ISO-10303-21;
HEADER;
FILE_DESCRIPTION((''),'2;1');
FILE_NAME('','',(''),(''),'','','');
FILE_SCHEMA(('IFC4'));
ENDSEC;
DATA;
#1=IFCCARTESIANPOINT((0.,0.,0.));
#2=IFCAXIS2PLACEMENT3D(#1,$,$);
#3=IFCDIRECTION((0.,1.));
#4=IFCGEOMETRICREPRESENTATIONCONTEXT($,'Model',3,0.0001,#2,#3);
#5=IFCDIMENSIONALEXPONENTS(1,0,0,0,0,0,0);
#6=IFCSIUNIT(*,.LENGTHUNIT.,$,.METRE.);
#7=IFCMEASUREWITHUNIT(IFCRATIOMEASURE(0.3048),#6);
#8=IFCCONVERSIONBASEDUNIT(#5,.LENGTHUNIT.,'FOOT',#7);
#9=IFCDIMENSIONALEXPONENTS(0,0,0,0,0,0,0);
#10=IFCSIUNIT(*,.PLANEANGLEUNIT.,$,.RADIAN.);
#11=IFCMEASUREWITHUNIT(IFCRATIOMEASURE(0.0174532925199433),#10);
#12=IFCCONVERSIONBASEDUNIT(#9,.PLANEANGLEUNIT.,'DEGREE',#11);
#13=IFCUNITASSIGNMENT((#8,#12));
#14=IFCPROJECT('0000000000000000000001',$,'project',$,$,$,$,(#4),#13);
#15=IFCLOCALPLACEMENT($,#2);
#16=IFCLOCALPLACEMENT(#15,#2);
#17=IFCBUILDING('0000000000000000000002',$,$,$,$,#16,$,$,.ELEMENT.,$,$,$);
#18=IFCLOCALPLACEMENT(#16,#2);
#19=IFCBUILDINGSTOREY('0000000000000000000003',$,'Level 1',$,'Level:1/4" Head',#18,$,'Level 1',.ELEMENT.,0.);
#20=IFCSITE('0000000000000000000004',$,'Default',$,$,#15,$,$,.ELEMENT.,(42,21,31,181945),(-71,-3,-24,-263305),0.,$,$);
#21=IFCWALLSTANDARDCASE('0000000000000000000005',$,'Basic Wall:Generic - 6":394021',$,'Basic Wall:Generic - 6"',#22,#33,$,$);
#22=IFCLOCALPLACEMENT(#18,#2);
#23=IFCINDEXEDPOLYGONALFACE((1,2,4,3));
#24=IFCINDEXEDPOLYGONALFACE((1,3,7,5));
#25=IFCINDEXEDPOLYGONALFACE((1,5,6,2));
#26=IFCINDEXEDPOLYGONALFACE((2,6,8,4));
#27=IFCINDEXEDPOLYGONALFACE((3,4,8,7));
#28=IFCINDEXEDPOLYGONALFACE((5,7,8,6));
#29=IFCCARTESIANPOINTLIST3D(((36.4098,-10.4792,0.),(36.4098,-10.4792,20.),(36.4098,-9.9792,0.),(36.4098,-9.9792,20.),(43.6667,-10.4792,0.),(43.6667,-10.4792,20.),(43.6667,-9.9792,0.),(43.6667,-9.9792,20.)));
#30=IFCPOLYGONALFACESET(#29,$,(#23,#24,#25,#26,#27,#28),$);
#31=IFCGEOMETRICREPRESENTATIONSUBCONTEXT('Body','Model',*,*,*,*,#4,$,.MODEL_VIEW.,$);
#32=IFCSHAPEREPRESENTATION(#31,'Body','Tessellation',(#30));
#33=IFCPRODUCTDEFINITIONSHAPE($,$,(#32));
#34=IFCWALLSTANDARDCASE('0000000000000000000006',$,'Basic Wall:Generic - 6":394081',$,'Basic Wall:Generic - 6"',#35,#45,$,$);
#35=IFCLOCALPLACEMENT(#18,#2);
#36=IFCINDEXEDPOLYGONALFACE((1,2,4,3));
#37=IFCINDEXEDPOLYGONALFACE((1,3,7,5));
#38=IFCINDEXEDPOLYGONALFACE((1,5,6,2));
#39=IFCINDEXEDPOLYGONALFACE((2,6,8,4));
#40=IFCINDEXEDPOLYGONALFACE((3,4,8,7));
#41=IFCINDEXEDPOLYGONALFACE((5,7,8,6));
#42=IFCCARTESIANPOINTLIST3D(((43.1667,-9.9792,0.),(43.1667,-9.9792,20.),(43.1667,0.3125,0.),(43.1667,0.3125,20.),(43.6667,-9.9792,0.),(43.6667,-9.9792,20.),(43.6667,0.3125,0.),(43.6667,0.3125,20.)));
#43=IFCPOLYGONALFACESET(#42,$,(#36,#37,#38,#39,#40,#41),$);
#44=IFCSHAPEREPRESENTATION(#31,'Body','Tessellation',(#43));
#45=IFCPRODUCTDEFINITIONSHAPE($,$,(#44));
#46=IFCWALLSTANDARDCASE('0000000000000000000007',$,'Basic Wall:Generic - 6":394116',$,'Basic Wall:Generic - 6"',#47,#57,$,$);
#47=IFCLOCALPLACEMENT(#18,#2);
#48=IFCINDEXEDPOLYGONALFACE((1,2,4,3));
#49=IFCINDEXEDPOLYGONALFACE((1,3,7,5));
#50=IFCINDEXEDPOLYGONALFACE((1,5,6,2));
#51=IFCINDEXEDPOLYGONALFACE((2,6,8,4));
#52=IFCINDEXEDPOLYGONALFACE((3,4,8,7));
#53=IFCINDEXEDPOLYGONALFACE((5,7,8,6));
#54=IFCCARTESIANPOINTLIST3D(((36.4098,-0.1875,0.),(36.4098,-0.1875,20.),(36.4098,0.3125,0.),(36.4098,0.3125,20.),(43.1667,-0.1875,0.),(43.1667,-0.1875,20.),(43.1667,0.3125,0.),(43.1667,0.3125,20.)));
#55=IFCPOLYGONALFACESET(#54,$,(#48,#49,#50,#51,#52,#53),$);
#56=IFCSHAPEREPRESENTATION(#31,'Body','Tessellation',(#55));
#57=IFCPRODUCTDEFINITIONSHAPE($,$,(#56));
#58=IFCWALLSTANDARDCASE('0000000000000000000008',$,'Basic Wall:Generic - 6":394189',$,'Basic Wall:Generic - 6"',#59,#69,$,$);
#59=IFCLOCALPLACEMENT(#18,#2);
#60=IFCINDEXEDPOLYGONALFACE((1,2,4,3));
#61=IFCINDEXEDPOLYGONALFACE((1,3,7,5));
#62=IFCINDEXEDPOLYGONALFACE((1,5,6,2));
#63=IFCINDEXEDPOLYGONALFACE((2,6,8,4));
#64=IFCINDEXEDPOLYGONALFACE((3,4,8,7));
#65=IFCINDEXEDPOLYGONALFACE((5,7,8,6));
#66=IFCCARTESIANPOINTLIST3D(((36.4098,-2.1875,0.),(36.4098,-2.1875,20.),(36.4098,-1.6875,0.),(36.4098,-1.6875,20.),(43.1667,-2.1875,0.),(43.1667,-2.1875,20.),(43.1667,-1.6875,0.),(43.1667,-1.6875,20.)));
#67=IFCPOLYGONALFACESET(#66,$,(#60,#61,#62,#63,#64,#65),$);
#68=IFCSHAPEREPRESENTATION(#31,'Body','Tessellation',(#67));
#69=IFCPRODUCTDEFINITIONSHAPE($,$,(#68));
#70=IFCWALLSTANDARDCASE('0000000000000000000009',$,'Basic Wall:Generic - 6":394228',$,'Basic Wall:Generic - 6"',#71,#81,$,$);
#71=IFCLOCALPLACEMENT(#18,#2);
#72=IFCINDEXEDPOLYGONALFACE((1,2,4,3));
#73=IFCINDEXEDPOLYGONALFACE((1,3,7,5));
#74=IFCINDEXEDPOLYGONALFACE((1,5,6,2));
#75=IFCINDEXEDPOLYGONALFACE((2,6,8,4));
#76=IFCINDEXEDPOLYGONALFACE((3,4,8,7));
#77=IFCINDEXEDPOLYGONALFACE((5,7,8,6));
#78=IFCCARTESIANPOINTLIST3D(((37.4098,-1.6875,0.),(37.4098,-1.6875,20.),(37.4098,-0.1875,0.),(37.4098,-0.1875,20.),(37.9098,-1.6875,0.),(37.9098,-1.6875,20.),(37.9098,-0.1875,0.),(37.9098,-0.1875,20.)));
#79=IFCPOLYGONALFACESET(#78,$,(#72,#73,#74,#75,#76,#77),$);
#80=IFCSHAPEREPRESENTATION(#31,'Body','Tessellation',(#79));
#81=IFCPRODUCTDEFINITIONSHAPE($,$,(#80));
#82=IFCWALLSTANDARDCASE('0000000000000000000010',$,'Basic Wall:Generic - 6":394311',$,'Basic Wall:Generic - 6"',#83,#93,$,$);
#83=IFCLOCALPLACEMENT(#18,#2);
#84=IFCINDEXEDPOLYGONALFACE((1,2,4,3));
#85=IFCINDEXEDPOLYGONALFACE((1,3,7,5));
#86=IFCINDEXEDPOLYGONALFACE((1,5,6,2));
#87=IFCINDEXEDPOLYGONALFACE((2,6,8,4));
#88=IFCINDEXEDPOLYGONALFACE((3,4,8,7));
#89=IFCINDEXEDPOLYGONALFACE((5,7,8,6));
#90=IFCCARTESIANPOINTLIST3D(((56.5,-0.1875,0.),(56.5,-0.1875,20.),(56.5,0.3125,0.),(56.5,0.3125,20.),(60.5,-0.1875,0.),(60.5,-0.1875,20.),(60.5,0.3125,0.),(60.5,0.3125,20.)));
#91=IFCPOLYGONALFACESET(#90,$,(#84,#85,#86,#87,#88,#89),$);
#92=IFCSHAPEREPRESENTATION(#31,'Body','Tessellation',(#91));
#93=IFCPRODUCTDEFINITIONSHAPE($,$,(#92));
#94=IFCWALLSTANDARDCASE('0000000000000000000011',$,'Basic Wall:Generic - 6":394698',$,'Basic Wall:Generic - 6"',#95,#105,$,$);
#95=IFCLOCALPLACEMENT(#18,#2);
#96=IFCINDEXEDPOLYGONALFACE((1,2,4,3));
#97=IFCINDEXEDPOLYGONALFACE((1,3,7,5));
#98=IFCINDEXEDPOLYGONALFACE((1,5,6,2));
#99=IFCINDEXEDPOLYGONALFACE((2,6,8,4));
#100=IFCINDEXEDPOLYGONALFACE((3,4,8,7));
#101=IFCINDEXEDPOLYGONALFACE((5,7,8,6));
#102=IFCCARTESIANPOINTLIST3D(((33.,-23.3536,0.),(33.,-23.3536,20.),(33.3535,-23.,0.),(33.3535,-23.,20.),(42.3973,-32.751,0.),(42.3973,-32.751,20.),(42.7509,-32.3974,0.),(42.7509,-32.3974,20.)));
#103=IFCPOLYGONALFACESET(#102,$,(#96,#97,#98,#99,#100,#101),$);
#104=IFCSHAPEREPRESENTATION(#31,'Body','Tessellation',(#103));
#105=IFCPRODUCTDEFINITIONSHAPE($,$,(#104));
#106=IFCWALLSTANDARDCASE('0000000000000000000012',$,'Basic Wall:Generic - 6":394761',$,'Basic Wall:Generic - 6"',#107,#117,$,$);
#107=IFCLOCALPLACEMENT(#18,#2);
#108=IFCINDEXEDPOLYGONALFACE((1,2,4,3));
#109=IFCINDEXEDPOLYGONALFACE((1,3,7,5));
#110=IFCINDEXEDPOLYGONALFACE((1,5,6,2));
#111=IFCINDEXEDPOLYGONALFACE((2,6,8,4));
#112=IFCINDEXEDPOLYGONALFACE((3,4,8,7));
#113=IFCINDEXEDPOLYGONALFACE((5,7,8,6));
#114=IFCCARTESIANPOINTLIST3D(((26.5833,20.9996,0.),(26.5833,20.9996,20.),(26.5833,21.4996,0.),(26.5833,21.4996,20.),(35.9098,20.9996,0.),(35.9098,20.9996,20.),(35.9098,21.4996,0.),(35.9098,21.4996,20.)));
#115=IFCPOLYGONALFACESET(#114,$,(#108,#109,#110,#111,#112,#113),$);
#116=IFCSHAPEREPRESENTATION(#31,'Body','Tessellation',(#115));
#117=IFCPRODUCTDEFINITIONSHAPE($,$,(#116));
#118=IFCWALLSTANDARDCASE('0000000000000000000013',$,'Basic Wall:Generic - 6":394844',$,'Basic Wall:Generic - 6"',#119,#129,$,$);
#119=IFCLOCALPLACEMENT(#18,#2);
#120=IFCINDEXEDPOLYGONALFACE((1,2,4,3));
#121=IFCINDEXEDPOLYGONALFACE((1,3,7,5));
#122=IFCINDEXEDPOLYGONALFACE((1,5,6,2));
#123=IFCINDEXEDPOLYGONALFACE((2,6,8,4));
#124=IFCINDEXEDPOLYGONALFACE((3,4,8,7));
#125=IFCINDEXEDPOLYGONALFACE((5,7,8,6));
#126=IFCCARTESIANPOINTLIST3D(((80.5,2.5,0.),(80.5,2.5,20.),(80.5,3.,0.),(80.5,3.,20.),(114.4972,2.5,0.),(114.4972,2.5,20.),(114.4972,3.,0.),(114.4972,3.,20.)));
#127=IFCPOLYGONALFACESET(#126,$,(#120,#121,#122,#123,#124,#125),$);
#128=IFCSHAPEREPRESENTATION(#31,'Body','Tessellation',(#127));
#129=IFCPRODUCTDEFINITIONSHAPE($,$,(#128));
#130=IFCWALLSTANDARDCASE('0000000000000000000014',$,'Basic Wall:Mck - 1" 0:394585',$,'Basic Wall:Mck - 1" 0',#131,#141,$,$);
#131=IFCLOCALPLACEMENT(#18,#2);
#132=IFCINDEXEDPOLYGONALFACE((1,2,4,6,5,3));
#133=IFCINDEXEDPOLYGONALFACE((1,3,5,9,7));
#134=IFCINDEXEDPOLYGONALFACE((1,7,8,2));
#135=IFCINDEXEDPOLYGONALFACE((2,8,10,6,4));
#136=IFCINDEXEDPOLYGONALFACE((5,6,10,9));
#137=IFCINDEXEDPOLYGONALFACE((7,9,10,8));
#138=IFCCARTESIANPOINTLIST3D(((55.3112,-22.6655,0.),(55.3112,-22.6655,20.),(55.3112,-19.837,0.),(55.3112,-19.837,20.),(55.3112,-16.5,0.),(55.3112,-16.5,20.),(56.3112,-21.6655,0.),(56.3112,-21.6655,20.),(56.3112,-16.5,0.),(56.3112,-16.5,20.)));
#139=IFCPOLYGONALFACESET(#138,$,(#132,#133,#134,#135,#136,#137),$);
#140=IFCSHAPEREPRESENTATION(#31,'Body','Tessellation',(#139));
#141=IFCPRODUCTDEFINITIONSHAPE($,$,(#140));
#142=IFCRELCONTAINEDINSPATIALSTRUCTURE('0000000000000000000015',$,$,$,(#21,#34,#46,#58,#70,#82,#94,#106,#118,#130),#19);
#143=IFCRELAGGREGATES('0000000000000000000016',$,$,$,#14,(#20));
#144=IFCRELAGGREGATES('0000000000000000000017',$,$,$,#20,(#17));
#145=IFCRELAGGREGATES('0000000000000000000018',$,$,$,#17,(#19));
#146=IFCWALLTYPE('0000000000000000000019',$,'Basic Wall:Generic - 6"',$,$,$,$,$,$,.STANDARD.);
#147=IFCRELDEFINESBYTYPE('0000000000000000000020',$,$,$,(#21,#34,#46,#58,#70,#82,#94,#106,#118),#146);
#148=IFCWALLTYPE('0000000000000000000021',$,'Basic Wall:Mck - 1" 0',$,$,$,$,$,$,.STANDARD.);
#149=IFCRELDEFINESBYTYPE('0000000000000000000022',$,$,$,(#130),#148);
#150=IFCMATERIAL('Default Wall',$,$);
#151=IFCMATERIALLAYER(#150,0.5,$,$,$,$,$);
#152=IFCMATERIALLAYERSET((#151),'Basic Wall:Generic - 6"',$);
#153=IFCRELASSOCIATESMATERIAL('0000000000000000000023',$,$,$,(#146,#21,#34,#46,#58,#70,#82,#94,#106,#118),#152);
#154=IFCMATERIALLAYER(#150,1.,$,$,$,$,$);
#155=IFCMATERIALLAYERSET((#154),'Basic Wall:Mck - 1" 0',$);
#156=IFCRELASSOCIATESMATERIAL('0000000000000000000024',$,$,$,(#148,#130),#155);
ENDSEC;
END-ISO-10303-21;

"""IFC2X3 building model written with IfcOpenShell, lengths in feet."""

from ifc_helpers import new_model, entity, si_unit, converted_unit, direction, frame, frame_2d, origin, place, context, subcontext, project, spatial, polyline, rectangle, outline, extrude, material, layer, layer_set, layer_usage, type_object, element, save


model = new_model("IFC2X3")

# Units and contexts
model_context = context("Model", 3, precision=0.0001, world=origin(), true_north=direction((0.0, 1.0)))
body_context = subcontext(model_context, "Body", "Model", "MODEL_VIEW")
ifc_project = project(units=[converted_unit("LENGTHUNIT", "FOOT", entity("IfcRatioMeasure", 0.3048), si_unit("LENGTHUNIT", "METRE"), dimensions=[1, 0, 0, 0, 0, 0, 0]), converted_unit("PLANEANGLEUNIT", "DEGREE", entity("IfcRatioMeasure", 0.0174532925199433), si_unit("PLANEANGLEUNIT", "RADIAN"), dimensions=[0, 0, 0, 0, 0, 0, 0])], contexts=[model_context])

# Site, building, storey
site_placement = place(None, origin())
site = spatial("IfcSite", under=ifc_project, at=site_placement, Name="Default", CompositionType="ELEMENT", RefLatitude=(42, 21, 31, 181945), RefLongitude=(-71, -3, -24, -263305), RefElevation=0.0)
building_placement = place(site_placement, origin())
building = spatial("IfcBuilding", under=site, at=building_placement, CompositionType="ELEMENT")
storey_placement = place(building_placement, origin())
storey = spatial("IfcBuildingStorey", under=building, at=storey_placement, Name="Level 1", ObjectType="Level:1/4\" Head", LongName="Level 1", CompositionType="ELEMENT", Elevation=0.0)

# Walls
ifc_material = material(Name="Default Wall")
ifc_layer_1 = layer(ifc_material, 0.5)
ifc_layer_set_1 = layer_set([ifc_layer_1], Name="Basic Wall:Generic - 6\"")
wall_type_1 = type_object("IfcWallType", Name="Basic Wall:Generic - 6\"", PredefinedType="STANDARD", material=ifc_layer_set_1)
ifc_layer_usage_1 = layer_usage(ifc_layer_set_1, "AXIS2", "NEGATIVE", 0.25)
wall_1_placement = place(storey_placement, frame((36.4098, -10.2292, 0.0)))
element("IfcWallStandardCase", 1, at=wall_1_placement, inside=storey, type_object=wall_type_1, material=ifc_layer_usage_1, Name="Basic Wall:Generic - 6\":394021", ObjectType="Basic Wall:Generic - 6\"", context=body_context, shape_type="SweptSolid", body=[
    extrude(rectangle(XDim=7.2568, YDim=0.5, at=frame_2d((3.6284, 0.0), x_axis=(-1.0, 0.0))), origin(), (0.0, 0.0, 1.0), 20.0),
])
ifc_layer_usage_2 = layer_usage(ifc_layer_set_1, "AXIS2", "NEGATIVE", 0.25)
wall_2_placement = place(storey_placement, frame((43.4167, -9.9792, 0.0), z_axis=(0.0, 0.0, 1.0), x_axis=(0.0, 1.0, 0.0)))
element("IfcWallStandardCase", 2, at=wall_2_placement, inside=storey, type_object=wall_type_1, material=ifc_layer_usage_2, Name="Basic Wall:Generic - 6\":394081", ObjectType="Basic Wall:Generic - 6\"", context=body_context, shape_type="SweptSolid", body=[
    extrude(rectangle(XDim=10.2917, YDim=0.5, at=frame_2d((5.1458, 0.0), x_axis=(-1.0, 0.0))), origin(), (0.0, 0.0, 1.0), 20.0),
])
ifc_layer_usage_3 = layer_usage(ifc_layer_set_1, "AXIS2", "NEGATIVE", 0.25)
wall_3_placement = place(storey_placement, frame((43.1667, 0.0625, 0.0), z_axis=(0.0, 0.0, 1.0), x_axis=(-1.0, 0.0, 0.0)))
element("IfcWallStandardCase", 3, at=wall_3_placement, inside=storey, type_object=wall_type_1, material=ifc_layer_usage_3, Name="Basic Wall:Generic - 6\":394116", ObjectType="Basic Wall:Generic - 6\"", context=body_context, shape_type="SweptSolid", body=[
    extrude(rectangle(XDim=6.7568, YDim=0.5, at=frame_2d((3.3784, 0.0), x_axis=(-1.0, 0.0))), origin(), (0.0, 0.0, 1.0), 20.0),
])
ifc_layer_usage_4 = layer_usage(ifc_layer_set_1, "AXIS2", "NEGATIVE", 0.25)
wall_4_placement = place(storey_placement, frame((36.4098, -1.9375, 0.0)))
element("IfcWallStandardCase", 4, at=wall_4_placement, inside=storey, type_object=wall_type_1, material=ifc_layer_usage_4, Name="Basic Wall:Generic - 6\":394189", ObjectType="Basic Wall:Generic - 6\"", context=body_context, shape_type="SweptSolid", body=[
    extrude(rectangle(XDim=6.7568, YDim=0.5, at=frame_2d((3.3784, 0.0), x_axis=(-1.0, 0.0))), origin(), (0.0, 0.0, 1.0), 20.0),
])
ifc_layer_usage_5 = layer_usage(ifc_layer_set_1, "AXIS2", "NEGATIVE", 0.25)
wall_5_placement = place(storey_placement, frame((37.6598, -0.1875, 0.0), z_axis=(0.0, 0.0, 1.0), x_axis=(0.0, -1.0, 0.0)))
element("IfcWallStandardCase", 5, at=wall_5_placement, inside=storey, type_object=wall_type_1, material=ifc_layer_usage_5, Name="Basic Wall:Generic - 6\":394228", ObjectType="Basic Wall:Generic - 6\"", context=body_context, shape_type="SweptSolid", body=[
    extrude(rectangle(XDim=1.5, YDim=0.5, at=frame_2d((0.75, 0.0), x_axis=(-1.0, 0.0))), origin(), (0.0, 0.0, 1.0), 20.0),
])
ifc_layer_usage_6 = layer_usage(ifc_layer_set_1, "AXIS2", "NEGATIVE", 0.25)
wall_6_placement = place(storey_placement, frame((56.5, 0.0625, 0.0)))
element("IfcWallStandardCase", 6, at=wall_6_placement, inside=storey, type_object=wall_type_1, material=ifc_layer_usage_6, Name="Basic Wall:Generic - 6\":394311", ObjectType="Basic Wall:Generic - 6\"", context=body_context, shape_type="SweptSolid", body=[
    extrude(rectangle(XDim=4.0, YDim=0.5, at=frame_2d((2.0, 0.0), x_axis=(-1.0, 0.0))), origin(), (0.0, 0.0, 1.0), 20.0),
])
ifc_layer_usage_7 = layer_usage(ifc_layer_set_1, "AXIS2", "NEGATIVE", 0.25)
wall_7_placement = place(storey_placement, frame((33.1767, -23.1768, 0.0), z_axis=(0.0, 0.0, 1.0), x_axis=(0.707107, -0.707107, 0.0)))
element("IfcWallStandardCase", 7, at=wall_7_placement, inside=storey, type_object=wall_type_1, material=ifc_layer_usage_7, Name="Basic Wall:Generic - 6\":394698", ObjectType="Basic Wall:Generic - 6\"", context=body_context, shape_type="SweptSolid", body=[
    extrude(rectangle(XDim=13.2899, YDim=0.5, at=frame_2d((6.6449, 0.0), x_axis=(-1.0, 0.0))), origin(), (0.0, 0.0, 1.0), 20.0),
])
ifc_layer_usage_8 = layer_usage(ifc_layer_set_1, "AXIS2", "NEGATIVE", 0.25)
wall_8_placement = place(storey_placement, frame((26.5833, 21.2496, 0.0)))
element("IfcWallStandardCase", 8, at=wall_8_placement, inside=storey, type_object=wall_type_1, material=ifc_layer_usage_8, Name="Basic Wall:Generic - 6\":394761", ObjectType="Basic Wall:Generic - 6\"", context=body_context, shape_type="SweptSolid", body=[
    extrude(rectangle(XDim=9.3265, YDim=0.5, at=frame_2d((4.6632, 0.0), x_axis=(-1.0, 0.0))), origin(), (0.0, 0.0, 1.0), 20.0),
])
ifc_layer_usage_9 = layer_usage(ifc_layer_set_1, "AXIS2", "NEGATIVE", 0.25)
wall_9_placement = place(storey_placement, frame((80.5, 2.75, 0.0)))
element("IfcWallStandardCase", 9, at=wall_9_placement, inside=storey, type_object=wall_type_1, material=ifc_layer_usage_9, Name="Basic Wall:Generic - 6\":394844", ObjectType="Basic Wall:Generic - 6\"", context=body_context, shape_type="SweptSolid", body=[
    extrude(rectangle(XDim=33.9972, YDim=0.5, at=frame_2d((16.9986, 0.0), x_axis=(-1.0, 0.0))), origin(), (0.0, 0.0, 1.0), 20.0),
])
ifc_layer_2 = layer(ifc_material, 1.0)
ifc_layer_set_2 = layer_set([ifc_layer_2], Name="Basic Wall:Mck - 1\" 0")
ifc_layer_usage_10 = layer_usage(ifc_layer_set_2, "AXIS2", "NEGATIVE", 0.5)
wall_type_2 = type_object("IfcWallType", Name="Basic Wall:Mck - 1\" 0", PredefinedType="STANDARD", material=ifc_layer_set_2)
wall_10_placement = place(storey_placement, frame((55.8112, -22.6655, 0.0), z_axis=(0.0, 0.0, 1.0), x_axis=(0.0, 1.0, 0.0)))
element("IfcWallStandardCase", 10, at=wall_10_placement, inside=storey, type_object=wall_type_2, material=ifc_layer_usage_10, Name="Basic Wall:Mck - 1\" 0:394585", ObjectType="Basic Wall:Mck - 1\" 0", context=body_context, shape_type="SweptSolid", body=[
    extrude(outline(polyline([(6.1655, -0.5), (6.1655, 0.5), (2.8284, 0.5), (0.0, 0.5), (1.0, -0.5), (6.1655, -0.5)])), origin(), (0.0, 0.0, 1.0), 20.0),
])

save(model, "model.ifc")
